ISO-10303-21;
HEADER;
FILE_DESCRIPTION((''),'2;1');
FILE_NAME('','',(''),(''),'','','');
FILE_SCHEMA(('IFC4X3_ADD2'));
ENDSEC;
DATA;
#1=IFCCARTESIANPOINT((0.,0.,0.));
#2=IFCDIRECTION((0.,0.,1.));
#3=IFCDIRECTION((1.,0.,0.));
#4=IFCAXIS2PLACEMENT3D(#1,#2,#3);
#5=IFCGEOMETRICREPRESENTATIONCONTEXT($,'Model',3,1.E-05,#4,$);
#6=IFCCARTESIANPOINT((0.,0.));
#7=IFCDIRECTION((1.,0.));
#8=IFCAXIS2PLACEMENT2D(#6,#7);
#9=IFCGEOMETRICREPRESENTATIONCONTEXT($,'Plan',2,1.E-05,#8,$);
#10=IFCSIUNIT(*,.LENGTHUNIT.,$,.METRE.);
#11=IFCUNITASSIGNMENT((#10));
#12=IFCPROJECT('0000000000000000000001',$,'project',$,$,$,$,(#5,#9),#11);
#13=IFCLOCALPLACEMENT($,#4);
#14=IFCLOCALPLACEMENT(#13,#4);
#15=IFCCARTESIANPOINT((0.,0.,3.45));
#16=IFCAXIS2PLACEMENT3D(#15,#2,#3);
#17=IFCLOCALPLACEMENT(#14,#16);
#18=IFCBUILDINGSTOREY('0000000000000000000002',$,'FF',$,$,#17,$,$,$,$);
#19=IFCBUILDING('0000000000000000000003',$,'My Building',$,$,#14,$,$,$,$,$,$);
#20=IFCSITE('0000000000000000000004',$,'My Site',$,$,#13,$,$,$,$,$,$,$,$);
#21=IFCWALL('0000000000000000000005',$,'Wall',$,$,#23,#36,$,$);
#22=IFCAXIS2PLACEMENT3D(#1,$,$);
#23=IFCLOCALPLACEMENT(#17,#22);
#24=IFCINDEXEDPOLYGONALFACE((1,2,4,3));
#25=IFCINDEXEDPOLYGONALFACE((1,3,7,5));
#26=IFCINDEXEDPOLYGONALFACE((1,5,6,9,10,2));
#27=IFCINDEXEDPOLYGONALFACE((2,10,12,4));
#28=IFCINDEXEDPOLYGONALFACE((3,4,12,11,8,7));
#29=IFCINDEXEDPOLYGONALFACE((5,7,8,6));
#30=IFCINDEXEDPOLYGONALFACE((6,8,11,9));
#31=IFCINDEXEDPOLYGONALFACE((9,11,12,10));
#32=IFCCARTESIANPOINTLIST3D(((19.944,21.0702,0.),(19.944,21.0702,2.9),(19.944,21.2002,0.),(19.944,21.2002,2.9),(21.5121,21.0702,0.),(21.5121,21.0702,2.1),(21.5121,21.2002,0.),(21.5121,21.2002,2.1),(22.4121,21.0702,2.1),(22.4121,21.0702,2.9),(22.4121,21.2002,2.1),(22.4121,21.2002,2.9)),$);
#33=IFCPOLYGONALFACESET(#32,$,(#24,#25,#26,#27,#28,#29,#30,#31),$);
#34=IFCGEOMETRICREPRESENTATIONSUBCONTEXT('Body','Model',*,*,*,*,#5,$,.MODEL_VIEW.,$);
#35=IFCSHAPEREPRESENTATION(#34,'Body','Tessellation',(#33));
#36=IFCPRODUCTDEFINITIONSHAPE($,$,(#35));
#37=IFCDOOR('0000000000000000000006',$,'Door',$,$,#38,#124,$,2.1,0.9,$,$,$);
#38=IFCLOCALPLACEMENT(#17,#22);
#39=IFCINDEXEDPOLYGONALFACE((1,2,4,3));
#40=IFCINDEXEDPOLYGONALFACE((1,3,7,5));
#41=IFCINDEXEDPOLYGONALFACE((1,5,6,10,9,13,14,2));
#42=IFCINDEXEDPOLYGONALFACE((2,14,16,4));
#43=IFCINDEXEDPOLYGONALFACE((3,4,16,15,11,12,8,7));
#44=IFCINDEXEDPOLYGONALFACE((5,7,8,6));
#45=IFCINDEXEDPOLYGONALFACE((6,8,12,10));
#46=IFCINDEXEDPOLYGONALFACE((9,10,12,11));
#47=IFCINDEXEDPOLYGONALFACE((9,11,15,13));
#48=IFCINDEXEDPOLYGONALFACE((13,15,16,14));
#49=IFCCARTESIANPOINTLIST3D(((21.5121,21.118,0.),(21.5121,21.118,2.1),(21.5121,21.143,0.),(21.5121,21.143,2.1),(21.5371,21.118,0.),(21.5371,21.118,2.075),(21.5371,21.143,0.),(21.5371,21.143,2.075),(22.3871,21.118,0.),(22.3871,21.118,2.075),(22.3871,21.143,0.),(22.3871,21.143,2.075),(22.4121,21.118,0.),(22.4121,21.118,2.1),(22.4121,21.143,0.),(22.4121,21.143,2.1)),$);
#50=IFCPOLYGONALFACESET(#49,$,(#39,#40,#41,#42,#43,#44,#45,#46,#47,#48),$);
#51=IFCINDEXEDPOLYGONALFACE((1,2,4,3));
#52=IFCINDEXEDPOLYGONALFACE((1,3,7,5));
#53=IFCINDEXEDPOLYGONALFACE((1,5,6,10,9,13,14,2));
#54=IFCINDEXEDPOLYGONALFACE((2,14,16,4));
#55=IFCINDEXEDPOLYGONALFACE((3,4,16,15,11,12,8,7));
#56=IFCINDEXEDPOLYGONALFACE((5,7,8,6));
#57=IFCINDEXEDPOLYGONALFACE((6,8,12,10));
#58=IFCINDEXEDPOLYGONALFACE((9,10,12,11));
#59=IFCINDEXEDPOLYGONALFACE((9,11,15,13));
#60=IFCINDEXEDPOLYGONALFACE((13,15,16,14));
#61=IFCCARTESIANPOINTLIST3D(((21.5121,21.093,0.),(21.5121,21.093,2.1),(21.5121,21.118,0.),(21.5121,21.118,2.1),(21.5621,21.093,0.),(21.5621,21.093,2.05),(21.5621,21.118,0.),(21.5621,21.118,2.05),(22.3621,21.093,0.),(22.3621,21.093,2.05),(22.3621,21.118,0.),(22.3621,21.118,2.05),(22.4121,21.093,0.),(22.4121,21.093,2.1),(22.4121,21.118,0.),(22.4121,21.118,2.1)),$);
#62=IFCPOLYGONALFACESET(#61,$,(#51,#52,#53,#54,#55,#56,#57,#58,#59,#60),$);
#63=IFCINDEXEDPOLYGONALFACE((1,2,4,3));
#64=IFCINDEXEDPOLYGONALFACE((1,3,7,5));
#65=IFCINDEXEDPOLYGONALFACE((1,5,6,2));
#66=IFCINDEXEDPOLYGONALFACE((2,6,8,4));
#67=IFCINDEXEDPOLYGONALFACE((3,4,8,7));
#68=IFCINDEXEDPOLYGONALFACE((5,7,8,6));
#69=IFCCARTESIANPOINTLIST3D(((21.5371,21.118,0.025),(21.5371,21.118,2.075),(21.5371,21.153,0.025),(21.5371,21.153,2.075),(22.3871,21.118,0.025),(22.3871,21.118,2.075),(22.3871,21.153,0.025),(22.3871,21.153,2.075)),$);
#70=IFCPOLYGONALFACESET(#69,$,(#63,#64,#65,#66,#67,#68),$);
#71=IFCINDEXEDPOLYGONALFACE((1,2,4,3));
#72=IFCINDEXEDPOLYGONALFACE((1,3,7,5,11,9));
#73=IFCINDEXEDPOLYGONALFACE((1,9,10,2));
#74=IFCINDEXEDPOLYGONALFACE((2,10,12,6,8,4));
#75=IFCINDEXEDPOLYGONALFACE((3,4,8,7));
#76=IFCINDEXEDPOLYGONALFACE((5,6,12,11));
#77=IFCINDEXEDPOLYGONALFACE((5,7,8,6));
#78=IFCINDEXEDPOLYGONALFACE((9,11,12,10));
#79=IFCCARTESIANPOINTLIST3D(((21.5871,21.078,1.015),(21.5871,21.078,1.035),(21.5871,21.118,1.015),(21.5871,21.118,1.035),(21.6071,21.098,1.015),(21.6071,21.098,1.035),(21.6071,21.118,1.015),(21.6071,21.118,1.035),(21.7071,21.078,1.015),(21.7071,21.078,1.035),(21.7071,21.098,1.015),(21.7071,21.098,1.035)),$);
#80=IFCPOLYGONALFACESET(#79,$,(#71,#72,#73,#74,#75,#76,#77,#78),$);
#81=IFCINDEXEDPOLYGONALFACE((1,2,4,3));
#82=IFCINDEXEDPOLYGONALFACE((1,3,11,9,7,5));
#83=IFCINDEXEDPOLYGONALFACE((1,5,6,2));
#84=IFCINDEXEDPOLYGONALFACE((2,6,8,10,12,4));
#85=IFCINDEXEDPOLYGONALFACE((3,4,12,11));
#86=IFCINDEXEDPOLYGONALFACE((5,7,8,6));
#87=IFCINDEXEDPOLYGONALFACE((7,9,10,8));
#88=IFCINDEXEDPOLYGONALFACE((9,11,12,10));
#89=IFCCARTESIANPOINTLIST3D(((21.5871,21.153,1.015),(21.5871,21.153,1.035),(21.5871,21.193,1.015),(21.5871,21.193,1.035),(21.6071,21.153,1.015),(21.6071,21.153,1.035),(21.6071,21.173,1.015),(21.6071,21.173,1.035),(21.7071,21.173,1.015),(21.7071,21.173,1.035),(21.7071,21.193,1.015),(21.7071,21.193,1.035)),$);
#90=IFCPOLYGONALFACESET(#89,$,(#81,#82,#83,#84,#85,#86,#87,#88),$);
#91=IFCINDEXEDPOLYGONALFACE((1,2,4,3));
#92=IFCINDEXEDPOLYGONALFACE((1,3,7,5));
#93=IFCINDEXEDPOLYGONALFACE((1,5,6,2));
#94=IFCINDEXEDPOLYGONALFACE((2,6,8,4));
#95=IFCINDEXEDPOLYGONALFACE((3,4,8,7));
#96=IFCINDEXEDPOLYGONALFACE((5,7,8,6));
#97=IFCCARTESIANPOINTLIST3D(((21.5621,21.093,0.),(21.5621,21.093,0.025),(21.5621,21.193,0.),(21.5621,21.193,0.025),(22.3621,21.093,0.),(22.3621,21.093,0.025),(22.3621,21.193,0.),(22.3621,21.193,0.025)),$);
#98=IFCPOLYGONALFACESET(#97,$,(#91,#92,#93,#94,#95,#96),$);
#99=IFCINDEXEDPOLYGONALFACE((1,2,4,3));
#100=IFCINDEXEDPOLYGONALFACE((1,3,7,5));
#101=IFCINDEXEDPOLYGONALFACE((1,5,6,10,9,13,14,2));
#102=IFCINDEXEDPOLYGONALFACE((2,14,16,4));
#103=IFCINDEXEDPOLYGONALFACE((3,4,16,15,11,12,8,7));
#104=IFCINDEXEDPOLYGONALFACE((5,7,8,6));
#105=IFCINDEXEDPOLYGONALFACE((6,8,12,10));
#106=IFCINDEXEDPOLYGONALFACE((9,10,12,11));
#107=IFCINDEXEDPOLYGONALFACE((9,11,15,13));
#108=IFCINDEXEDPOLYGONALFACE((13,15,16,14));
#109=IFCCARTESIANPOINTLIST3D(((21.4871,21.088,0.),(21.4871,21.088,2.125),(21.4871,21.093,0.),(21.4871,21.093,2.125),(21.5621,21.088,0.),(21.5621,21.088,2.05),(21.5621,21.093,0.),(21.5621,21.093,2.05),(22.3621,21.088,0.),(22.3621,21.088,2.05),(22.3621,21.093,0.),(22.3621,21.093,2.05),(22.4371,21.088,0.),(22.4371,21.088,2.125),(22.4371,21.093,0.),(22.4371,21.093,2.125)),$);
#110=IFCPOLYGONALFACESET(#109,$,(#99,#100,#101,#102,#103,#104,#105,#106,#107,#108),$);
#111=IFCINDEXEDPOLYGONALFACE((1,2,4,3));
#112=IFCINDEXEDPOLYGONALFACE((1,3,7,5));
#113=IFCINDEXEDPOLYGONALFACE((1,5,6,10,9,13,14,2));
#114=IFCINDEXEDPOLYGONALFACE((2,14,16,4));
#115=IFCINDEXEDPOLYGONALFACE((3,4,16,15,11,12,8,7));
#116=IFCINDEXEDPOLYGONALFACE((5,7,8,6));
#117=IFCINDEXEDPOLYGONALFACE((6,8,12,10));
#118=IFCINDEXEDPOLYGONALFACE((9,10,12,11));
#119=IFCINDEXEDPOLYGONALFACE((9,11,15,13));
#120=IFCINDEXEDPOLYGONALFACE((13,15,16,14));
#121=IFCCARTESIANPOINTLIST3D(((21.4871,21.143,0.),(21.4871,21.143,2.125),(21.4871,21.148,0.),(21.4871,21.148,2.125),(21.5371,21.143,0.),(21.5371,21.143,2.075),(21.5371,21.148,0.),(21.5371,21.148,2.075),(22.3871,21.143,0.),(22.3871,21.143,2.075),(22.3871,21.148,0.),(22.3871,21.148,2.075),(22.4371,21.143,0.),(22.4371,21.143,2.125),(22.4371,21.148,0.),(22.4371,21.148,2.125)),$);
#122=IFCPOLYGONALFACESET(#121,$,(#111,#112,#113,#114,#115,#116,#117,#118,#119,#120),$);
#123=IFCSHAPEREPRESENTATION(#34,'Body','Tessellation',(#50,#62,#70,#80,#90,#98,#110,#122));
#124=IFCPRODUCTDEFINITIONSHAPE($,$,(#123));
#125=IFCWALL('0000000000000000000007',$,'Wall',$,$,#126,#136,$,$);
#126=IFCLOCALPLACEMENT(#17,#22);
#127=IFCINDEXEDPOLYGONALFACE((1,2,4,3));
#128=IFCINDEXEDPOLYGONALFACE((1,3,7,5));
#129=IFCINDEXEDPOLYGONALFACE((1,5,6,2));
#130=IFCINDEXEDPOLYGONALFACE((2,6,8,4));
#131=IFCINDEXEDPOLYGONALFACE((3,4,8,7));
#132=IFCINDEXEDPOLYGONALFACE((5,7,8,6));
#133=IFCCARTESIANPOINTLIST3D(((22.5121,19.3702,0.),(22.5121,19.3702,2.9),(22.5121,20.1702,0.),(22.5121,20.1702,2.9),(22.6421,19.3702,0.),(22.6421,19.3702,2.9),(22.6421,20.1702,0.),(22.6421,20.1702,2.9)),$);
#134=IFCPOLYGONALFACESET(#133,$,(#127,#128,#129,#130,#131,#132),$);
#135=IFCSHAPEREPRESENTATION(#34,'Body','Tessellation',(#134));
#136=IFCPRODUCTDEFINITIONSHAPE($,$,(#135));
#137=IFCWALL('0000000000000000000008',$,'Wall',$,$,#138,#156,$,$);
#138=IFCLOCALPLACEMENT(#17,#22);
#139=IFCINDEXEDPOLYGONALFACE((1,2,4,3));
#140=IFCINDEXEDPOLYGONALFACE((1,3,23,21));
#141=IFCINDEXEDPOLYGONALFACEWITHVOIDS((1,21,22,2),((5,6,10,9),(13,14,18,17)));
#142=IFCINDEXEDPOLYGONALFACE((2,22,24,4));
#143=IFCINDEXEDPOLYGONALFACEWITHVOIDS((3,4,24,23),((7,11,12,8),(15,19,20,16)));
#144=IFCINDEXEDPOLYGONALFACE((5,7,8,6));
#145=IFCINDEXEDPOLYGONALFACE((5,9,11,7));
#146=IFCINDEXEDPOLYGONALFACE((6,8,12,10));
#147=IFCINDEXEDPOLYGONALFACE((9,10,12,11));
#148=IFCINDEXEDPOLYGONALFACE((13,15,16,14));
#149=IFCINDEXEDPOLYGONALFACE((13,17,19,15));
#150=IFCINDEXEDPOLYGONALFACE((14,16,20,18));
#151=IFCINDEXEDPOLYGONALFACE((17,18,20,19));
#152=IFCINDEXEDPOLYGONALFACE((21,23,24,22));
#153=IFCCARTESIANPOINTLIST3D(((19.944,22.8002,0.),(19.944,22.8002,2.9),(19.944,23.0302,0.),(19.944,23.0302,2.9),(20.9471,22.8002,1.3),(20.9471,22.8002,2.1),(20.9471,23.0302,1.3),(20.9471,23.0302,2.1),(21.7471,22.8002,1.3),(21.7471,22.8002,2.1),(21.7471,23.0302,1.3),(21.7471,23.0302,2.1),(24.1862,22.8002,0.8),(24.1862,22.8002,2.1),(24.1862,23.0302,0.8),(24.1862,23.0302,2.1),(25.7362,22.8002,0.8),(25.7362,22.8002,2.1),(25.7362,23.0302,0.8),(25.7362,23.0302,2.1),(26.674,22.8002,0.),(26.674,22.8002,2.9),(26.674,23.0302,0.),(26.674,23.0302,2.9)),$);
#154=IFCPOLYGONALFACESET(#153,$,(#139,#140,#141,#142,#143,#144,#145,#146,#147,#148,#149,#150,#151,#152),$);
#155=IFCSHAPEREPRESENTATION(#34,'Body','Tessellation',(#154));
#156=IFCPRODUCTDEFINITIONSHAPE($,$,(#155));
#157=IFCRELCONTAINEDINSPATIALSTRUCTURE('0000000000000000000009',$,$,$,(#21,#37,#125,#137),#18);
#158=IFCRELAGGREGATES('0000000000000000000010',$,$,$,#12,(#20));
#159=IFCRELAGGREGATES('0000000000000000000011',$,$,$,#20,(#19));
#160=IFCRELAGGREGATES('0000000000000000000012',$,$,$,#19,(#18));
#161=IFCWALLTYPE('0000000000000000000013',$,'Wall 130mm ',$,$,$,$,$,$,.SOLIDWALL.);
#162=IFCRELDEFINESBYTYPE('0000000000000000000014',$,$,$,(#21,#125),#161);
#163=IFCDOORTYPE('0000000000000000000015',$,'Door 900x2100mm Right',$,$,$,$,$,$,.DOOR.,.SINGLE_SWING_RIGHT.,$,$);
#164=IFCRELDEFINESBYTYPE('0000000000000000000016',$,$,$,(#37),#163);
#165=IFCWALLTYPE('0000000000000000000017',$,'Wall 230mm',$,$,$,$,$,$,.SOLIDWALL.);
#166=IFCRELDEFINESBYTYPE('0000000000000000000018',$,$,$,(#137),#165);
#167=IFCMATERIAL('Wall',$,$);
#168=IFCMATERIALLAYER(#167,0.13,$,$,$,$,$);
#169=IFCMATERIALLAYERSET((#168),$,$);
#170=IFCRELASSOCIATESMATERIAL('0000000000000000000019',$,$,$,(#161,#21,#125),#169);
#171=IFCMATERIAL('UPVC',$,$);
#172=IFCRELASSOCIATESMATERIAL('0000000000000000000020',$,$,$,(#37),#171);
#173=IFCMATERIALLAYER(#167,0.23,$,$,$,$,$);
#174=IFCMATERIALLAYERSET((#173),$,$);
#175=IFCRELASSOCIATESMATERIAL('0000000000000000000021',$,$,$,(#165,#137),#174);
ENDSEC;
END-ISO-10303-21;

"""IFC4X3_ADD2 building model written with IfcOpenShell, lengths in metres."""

from ifc_helpers import new_model, entity, si_unit, frame, origin_with_axes, origin_2d_with_axis, place, context, subcontext, project, spatial, line, indexed_curve, outline, extrude, shape, source, transform, mapped, material, layer, layer_set, layer_usage, type_object, type_shapes, element, fill, save


model = new_model("IFC4X3_ADD2")

# Units and contexts
model_context = context("Model", 3, precision=1e-05, world=origin_with_axes())
plan_context = context("Plan", 2, precision=1e-05, world=origin_2d_with_axis())
body_context_1 = subcontext(model_context, "Body", "Model", "MODEL_VIEW")
body_context_2 = subcontext(plan_context, "Body", "Plan", "PLAN_VIEW")
ifc_project = project(units=[si_unit("LENGTHUNIT", "METRE")], contexts=[model_context, plan_context])

# Site, building, storey
site_placement = place(None, origin_with_axes())
site = spatial("IfcSite", under=ifc_project, at=site_placement, Name="My Site")
building_placement = place(site_placement, origin_with_axes())
building = spatial("IfcBuilding", under=site, at=building_placement, Name="My Building")
storey_placement = place(building_placement, frame((0.0, 0.0, 3.45), z_axis=(0.0, 0.0, 1.0), x_axis=(1.0, 0.0, 0.0)))
storey = spatial("IfcBuildingStorey", under=building, at=storey_placement, Name="FF")

# Wall, opening, door
ifc_material_1 = material(Name="Wall")
ifc_layer_1 = layer(ifc_material_1, 0.13)
ifc_layer_set_1 = layer_set([ifc_layer_1])
ifc_layer_usage_1 = layer_usage(ifc_layer_set_1, "AXIS2", "POSITIVE", 0.0)
wall_type_1 = type_object("IfcWallType", Name="Wall 130mm ", PredefinedType="SOLIDWALL", material=ifc_layer_set_1)
wall_1_placement = place(storey_placement, frame((22.4121, 21.2002, 0.0), z_axis=(0.0, 0.0, 1.0), x_axis=(-1.0, 0.0, 0.0)))
wall_1 = element("IfcWall", 1, at=wall_1_placement, inside=storey, type_object=wall_type_1, material=ifc_layer_usage_1, Name="Wall", context=body_context_1, shape_type="SweptSolid", body=[
    extrude(outline(indexed_curve([(0.0, 0.0), (0.0, 0.13), (2.4681, 0.13), (2.4681, 0.0), (0.0, 0.0)], self_intersect=False)), origin_with_axes(), (0.0, 0.0, 1.0), 2.9),
])
shared_shape_1 = source(origin_with_axes(), body_context_1, "Body", "SweptSolid", [
    extrude(outline(indexed_curve([(0.0, 0.0), (0.9, 0.0), (0.9, 2.1), (0.0, 2.1)], segments=[line(1, 2, 3, 4, 1)])), frame((0.0, -0.6, 0.0), z_axis=(0.0, -1.0, 0.0), x_axis=(1.0, 0.0, 0.0)), (0.0, 0.0, -1.0), 1.2),
])
opening_1_placement = place(wall_1_placement, frame((0.9, 0.1072, 0.0), z_axis=(0.0, 0.0, 1.0), x_axis=(-1.0, 0.0, 0.0)))
opening_1 = element("IfcOpeningElement", 2, at=opening_1_placement, cuts=wall_1, PredefinedType="OPENING", context=body_context_1, shape_type="MappedRepresentation", body=[
    mapped(shared_shape_1, transform((0.0, 0.0, 0.0), x_axis=(1.0, 0.0, 0.0), y_axis=(0.0, 1.0, 0.0), z_axis=(0.0, 0.0, 1.0), scale=1.0)),
])
ifc_material_2 = material(Name="UPVC")
door_type_1 = type_object("IfcDoorType", Name="Door 900x2100mm Right", OperationType="SINGLE_SWING_RIGHT", PredefinedType="DOOR")
shared_shape_2 = source(origin_with_axes(), body_context_1, "Body", "SweptSolid", [
    extrude(outline(indexed_curve([(0.0, 0.0), (0.0, 2.1), (0.9, 2.1), (0.9, 0.0), (0.875, 0.0), (0.875, 2.075), (0.025, 2.075), (0.025, 0.0)], segments=[line(1, 2, 3, 4, 5, 6, 7, 8, 1)])), frame((0.0, 0.025, 0.0), z_axis=(0.0, -1.0, 0.0), x_axis=(1.0, 0.0, 0.0)), (0.0, 0.0, -1.0), 0.025),
    extrude(outline(indexed_curve([(0.0, 0.0), (0.0, 2.1), (0.9, 2.1), (0.9, 0.0), (0.85, 0.0), (0.85, 2.05), (0.05, 2.05), (0.05, 0.0)], segments=[line(1, 2, 3, 4, 5, 6, 7, 8, 1)])), frame((0.0, 0.0, 0.0), z_axis=(0.0, -1.0, 0.0), x_axis=(1.0, 0.0, 0.0)), (0.0, 0.0, -1.0), 0.025),
    extrude(outline(indexed_curve([(0.0, 0.0), (0.85, 0.0), (0.85, 0.035), (0.0, 0.035)], segments=[line(1, 2, 3, 4, 1)])), frame((0.025, 0.025, 0.025), z_axis=(0.0, 0.0, 1.0), x_axis=(1.0, 0.0, 0.0)), (0.0, 0.0, 1.0), 2.05),
    extrude(outline(indexed_curve([(0.0, 0.0), (0.0, -0.04), (0.12, -0.04), (0.12, -0.02), (0.02, -0.02), (0.02, 0.0)], segments=[line(1, 2, 3, 4, 5, 6, 1)])), frame((0.075, 0.025, 1.015), z_axis=(0.0, 0.0, 1.0), x_axis=(1.0, 0.0, 0.0)), (0.0, 0.0, 1.0), 0.02),
    extrude(outline(indexed_curve([(0.0, 0.0), (0.0, 0.04), (0.12, 0.04), (0.12, 0.02), (0.02, 0.02), (0.02, 0.0)], segments=[line(1, 2, 3, 4, 5, 6, 1)])), frame((0.075, 0.06, 1.015), z_axis=(0.0, 0.0, 1.0), x_axis=(1.0, 0.0, 0.0)), (0.0, 0.0, 1.0), 0.02),
    extrude(outline(indexed_curve([(0.0, 0.0), (0.8, 0.0), (0.8, 0.1), (0.0, 0.1)], segments=[line(1, 2, 3, 4, 1)])), frame((0.05, 0.0, 0.0), z_axis=(0.0, 0.0, 1.0), x_axis=(1.0, 0.0, 0.0)), (0.0, 0.0, 1.0), 0.025),
    extrude(outline(indexed_curve([(0.0, 0.0), (0.0, 2.125), (0.95, 2.125), (0.95, 0.0), (0.875, 0.0), (0.875, 2.05), (0.075, 2.05), (0.075, 0.0)], segments=[line(1, 2, 3, 4, 5, 6, 7, 8, 1)])), frame((-0.025, -0.005, 0.0), z_axis=(0.0, -1.0, 0.0), x_axis=(1.0, 0.0, 0.0)), (0.0, 0.0, -1.0), 0.005),
    extrude(outline(indexed_curve([(0.0, 0.0), (0.0, 2.125), (0.95, 2.125), (0.95, 0.0), (0.9, 0.0), (0.9, 2.075), (0.05, 2.075), (0.05, 0.0)], segments=[line(1, 2, 3, 4, 5, 6, 7, 8, 1)])), frame((-0.025, 0.05, 0.0), z_axis=(0.0, -1.0, 0.0), x_axis=(1.0, 0.0, 0.0)), (0.0, 0.0, -1.0), 0.005),
])
shared_shape_3 = source(origin_with_axes(), body_context_2, "Body", "Curve2D", [
    entity("IfcIndexedPolyCurve", entity("IfcCartesianPointList2D", [[0.0, 0.0], [0.0, 0.05], [0.025, 0.05], [0.025, 0.025], [0.05, 0.025], [0.05, 0.0]]), [entity("IfcLineIndex", [1, 2, 3, 4, 5, 6, 1])]),
    entity("IfcIndexedPolyCurve", entity("IfcCartesianPointList2D", [[0.9, 0.0], [0.9, 0.05], [0.875, 0.05], [0.875, 0.025], [0.85, 0.025], [0.85, 0.0]]), [entity("IfcLineIndex", [1, 2, 3, 4, 5, 6, 1])]),
    entity("IfcTrimmedCurve", entity("IfcEllipse", entity("IfcAxis2Placement2D", entity("IfcCartesianPoint", [0.84, 0.05]), entity("IfcDirection", [1.0, 0.0])), 0.815, 0.85), [entity("IfcCartesianPoint", [0.84, 0.9])], [entity("IfcCartesianPoint", [0.025, 0.05])], True, "CARTESIAN"),
    entity("IfcIndexedPolyCurve", entity("IfcCartesianPointList2D", [[0.875, 0.05], [0.84, 0.05], [0.84, 0.9], [0.875, 0.9]]), [entity("IfcLineIndex", [1, 2, 3, 4, 1])]),
])
type_shapes(door_type_1, [shared_shape_2, shared_shape_3])
door_1_placement = place(opening_1_placement, frame((0.0, 0.0, 0.0), z_axis=(0.0, 0.0, 1.0), x_axis=(1.0, 0.0, 0.0)))
door_1 = element("IfcDoor", 3, at=door_1_placement, inside=storey, type_object=door_type_1, material=ifc_material_2, Name="Door", OverallHeight=2.1, OverallWidth=0.9, shapes=[
    shape(body_context_1, "Body", "MappedRepresentation", [mapped(shared_shape_2, transform((0.0, 0.0, 0.0), x_axis=(1.0, 0.0, 0.0), y_axis=(0.0, 1.0, 0.0), z_axis=(0.0, 0.0, 1.0), scale=1.0))]),
    shape(body_context_2, "Body", "MappedRepresentation", [mapped(shared_shape_3, transform((0.0, 0.0, 0.0), x_axis=(1.0, 0.0, 0.0), y_axis=(0.0, 1.0, 0.0), z_axis=(0.0, 0.0, 1.0), scale=1.0))]),
])
fill(opening_1, door_1)

# Wall
ifc_layer_usage_2 = layer_usage(ifc_layer_set_1, "AXIS2", "POSITIVE", 0.0)
wall_2_placement = place(storey_placement, frame((22.6421, 19.3702, 0.0), z_axis=(0.0, 0.0, 1.0), x_axis=(0.000001, 1.0, 0.0)))
element("IfcWall", 4, at=wall_2_placement, inside=storey, type_object=wall_type_1, material=ifc_layer_usage_2, Name="Wall", context=body_context_1, shape_type="SweptSolid", body=[
    extrude(outline(indexed_curve([(0.0, 0.0), (0.0, 0.13), (0.8, 0.13), (0.8, 0.0), (0.0, 0.0)], self_intersect=False)), origin_with_axes(), (0.0, 0.0, 1.0), 2.9),
])

# Wall, openings
ifc_layer_2 = layer(ifc_material_1, 0.23)
ifc_layer_set_2 = layer_set([ifc_layer_2])
ifc_layer_usage_3 = layer_usage(ifc_layer_set_2, "AXIS2", "POSITIVE", 0.0)
wall_type_2 = type_object("IfcWallType", Name="Wall 230mm", PredefinedType="SOLIDWALL", material=ifc_layer_set_2)
wall_3_placement = place(storey_placement, frame((26.674, 23.0302, 0.0), z_axis=(0.0, 0.0, 1.0), x_axis=(-1.0, 0.0, 0.0)))
wall_3 = element("IfcWall", 5, at=wall_3_placement, inside=storey, type_object=wall_type_2, material=ifc_layer_usage_3, Name="Wall", context=body_context_1, shape_type="SweptSolid", body=[
    extrude(outline(indexed_curve([(0.0, 0.0), (0.0, 0.23), (6.73, 0.23), (6.73, 0.0), (0.0, 0.0)], self_intersect=False)), origin_with_axes(), (0.0, 0.0, 1.0), 2.9),
])
shared_shape_4 = source(origin_with_axes(), body_context_1, "Body", "SweptSolid", [
    extrude(outline(indexed_curve([(0.0, 0.0), (1.55, 0.0), (1.55, 1.3), (0.0, 1.3)], segments=[line(1, 2, 3, 4, 1)])), frame((-0.775, -0.6, 0.0), z_axis=(0.0, -1.0, 0.0), x_axis=(1.0, 0.0, 0.0)), (0.0, 0.0, -1.0), 1.2),
])
opening_2_placement = place(wall_3_placement, frame((1.7127, 0.0, 0.8), z_axis=(0.0, 0.0, 1.0), x_axis=(1.0, 0.0, 0.0)))
element("IfcOpeningElement", 6, at=opening_2_placement, cuts=wall_3, PredefinedType="OPENING", context=body_context_1, shape_type="MappedRepresentation", body=[
    mapped(shared_shape_4, transform((0.0, 0.0, 0.0), x_axis=(1.0, 0.0, 0.0), y_axis=(0.0, 1.0, 0.0), z_axis=(0.0, 0.0, 1.0), scale=1.0)),
])
shared_shape_5 = source(origin_with_axes(), body_context_1, "Body", "SweptSolid", [
    extrude(outline(indexed_curve([(0.0, 0.0), (0.8, 0.0), (0.8, 0.8), (0.0, 0.8)], segments=[line(1, 2, 3, 4, 1)])), frame((-0.4, -0.6, 0.0), z_axis=(0.0, -1.0, 0.0), x_axis=(1.0, 0.0, 0.0)), (0.0, 0.0, -1.0), 1.2),
])
opening_3_placement = place(wall_3_placement, frame((5.3269, 0.0, 1.3), z_axis=(0.0, 0.0, 1.0), x_axis=(1.0, 0.0, 0.0)))
element("IfcOpeningElement", 7, at=opening_3_placement, cuts=wall_3, PredefinedType="OPENING", context=body_context_1, shape_type="MappedRepresentation", body=[
    mapped(shared_shape_5, transform((0.0, 0.0, 0.0), x_axis=(1.0, 0.0, 0.0), y_axis=(0.0, 1.0, 0.0), z_axis=(0.0, 0.0, 1.0), scale=1.0)),
])

save(model, "model.ifc")
